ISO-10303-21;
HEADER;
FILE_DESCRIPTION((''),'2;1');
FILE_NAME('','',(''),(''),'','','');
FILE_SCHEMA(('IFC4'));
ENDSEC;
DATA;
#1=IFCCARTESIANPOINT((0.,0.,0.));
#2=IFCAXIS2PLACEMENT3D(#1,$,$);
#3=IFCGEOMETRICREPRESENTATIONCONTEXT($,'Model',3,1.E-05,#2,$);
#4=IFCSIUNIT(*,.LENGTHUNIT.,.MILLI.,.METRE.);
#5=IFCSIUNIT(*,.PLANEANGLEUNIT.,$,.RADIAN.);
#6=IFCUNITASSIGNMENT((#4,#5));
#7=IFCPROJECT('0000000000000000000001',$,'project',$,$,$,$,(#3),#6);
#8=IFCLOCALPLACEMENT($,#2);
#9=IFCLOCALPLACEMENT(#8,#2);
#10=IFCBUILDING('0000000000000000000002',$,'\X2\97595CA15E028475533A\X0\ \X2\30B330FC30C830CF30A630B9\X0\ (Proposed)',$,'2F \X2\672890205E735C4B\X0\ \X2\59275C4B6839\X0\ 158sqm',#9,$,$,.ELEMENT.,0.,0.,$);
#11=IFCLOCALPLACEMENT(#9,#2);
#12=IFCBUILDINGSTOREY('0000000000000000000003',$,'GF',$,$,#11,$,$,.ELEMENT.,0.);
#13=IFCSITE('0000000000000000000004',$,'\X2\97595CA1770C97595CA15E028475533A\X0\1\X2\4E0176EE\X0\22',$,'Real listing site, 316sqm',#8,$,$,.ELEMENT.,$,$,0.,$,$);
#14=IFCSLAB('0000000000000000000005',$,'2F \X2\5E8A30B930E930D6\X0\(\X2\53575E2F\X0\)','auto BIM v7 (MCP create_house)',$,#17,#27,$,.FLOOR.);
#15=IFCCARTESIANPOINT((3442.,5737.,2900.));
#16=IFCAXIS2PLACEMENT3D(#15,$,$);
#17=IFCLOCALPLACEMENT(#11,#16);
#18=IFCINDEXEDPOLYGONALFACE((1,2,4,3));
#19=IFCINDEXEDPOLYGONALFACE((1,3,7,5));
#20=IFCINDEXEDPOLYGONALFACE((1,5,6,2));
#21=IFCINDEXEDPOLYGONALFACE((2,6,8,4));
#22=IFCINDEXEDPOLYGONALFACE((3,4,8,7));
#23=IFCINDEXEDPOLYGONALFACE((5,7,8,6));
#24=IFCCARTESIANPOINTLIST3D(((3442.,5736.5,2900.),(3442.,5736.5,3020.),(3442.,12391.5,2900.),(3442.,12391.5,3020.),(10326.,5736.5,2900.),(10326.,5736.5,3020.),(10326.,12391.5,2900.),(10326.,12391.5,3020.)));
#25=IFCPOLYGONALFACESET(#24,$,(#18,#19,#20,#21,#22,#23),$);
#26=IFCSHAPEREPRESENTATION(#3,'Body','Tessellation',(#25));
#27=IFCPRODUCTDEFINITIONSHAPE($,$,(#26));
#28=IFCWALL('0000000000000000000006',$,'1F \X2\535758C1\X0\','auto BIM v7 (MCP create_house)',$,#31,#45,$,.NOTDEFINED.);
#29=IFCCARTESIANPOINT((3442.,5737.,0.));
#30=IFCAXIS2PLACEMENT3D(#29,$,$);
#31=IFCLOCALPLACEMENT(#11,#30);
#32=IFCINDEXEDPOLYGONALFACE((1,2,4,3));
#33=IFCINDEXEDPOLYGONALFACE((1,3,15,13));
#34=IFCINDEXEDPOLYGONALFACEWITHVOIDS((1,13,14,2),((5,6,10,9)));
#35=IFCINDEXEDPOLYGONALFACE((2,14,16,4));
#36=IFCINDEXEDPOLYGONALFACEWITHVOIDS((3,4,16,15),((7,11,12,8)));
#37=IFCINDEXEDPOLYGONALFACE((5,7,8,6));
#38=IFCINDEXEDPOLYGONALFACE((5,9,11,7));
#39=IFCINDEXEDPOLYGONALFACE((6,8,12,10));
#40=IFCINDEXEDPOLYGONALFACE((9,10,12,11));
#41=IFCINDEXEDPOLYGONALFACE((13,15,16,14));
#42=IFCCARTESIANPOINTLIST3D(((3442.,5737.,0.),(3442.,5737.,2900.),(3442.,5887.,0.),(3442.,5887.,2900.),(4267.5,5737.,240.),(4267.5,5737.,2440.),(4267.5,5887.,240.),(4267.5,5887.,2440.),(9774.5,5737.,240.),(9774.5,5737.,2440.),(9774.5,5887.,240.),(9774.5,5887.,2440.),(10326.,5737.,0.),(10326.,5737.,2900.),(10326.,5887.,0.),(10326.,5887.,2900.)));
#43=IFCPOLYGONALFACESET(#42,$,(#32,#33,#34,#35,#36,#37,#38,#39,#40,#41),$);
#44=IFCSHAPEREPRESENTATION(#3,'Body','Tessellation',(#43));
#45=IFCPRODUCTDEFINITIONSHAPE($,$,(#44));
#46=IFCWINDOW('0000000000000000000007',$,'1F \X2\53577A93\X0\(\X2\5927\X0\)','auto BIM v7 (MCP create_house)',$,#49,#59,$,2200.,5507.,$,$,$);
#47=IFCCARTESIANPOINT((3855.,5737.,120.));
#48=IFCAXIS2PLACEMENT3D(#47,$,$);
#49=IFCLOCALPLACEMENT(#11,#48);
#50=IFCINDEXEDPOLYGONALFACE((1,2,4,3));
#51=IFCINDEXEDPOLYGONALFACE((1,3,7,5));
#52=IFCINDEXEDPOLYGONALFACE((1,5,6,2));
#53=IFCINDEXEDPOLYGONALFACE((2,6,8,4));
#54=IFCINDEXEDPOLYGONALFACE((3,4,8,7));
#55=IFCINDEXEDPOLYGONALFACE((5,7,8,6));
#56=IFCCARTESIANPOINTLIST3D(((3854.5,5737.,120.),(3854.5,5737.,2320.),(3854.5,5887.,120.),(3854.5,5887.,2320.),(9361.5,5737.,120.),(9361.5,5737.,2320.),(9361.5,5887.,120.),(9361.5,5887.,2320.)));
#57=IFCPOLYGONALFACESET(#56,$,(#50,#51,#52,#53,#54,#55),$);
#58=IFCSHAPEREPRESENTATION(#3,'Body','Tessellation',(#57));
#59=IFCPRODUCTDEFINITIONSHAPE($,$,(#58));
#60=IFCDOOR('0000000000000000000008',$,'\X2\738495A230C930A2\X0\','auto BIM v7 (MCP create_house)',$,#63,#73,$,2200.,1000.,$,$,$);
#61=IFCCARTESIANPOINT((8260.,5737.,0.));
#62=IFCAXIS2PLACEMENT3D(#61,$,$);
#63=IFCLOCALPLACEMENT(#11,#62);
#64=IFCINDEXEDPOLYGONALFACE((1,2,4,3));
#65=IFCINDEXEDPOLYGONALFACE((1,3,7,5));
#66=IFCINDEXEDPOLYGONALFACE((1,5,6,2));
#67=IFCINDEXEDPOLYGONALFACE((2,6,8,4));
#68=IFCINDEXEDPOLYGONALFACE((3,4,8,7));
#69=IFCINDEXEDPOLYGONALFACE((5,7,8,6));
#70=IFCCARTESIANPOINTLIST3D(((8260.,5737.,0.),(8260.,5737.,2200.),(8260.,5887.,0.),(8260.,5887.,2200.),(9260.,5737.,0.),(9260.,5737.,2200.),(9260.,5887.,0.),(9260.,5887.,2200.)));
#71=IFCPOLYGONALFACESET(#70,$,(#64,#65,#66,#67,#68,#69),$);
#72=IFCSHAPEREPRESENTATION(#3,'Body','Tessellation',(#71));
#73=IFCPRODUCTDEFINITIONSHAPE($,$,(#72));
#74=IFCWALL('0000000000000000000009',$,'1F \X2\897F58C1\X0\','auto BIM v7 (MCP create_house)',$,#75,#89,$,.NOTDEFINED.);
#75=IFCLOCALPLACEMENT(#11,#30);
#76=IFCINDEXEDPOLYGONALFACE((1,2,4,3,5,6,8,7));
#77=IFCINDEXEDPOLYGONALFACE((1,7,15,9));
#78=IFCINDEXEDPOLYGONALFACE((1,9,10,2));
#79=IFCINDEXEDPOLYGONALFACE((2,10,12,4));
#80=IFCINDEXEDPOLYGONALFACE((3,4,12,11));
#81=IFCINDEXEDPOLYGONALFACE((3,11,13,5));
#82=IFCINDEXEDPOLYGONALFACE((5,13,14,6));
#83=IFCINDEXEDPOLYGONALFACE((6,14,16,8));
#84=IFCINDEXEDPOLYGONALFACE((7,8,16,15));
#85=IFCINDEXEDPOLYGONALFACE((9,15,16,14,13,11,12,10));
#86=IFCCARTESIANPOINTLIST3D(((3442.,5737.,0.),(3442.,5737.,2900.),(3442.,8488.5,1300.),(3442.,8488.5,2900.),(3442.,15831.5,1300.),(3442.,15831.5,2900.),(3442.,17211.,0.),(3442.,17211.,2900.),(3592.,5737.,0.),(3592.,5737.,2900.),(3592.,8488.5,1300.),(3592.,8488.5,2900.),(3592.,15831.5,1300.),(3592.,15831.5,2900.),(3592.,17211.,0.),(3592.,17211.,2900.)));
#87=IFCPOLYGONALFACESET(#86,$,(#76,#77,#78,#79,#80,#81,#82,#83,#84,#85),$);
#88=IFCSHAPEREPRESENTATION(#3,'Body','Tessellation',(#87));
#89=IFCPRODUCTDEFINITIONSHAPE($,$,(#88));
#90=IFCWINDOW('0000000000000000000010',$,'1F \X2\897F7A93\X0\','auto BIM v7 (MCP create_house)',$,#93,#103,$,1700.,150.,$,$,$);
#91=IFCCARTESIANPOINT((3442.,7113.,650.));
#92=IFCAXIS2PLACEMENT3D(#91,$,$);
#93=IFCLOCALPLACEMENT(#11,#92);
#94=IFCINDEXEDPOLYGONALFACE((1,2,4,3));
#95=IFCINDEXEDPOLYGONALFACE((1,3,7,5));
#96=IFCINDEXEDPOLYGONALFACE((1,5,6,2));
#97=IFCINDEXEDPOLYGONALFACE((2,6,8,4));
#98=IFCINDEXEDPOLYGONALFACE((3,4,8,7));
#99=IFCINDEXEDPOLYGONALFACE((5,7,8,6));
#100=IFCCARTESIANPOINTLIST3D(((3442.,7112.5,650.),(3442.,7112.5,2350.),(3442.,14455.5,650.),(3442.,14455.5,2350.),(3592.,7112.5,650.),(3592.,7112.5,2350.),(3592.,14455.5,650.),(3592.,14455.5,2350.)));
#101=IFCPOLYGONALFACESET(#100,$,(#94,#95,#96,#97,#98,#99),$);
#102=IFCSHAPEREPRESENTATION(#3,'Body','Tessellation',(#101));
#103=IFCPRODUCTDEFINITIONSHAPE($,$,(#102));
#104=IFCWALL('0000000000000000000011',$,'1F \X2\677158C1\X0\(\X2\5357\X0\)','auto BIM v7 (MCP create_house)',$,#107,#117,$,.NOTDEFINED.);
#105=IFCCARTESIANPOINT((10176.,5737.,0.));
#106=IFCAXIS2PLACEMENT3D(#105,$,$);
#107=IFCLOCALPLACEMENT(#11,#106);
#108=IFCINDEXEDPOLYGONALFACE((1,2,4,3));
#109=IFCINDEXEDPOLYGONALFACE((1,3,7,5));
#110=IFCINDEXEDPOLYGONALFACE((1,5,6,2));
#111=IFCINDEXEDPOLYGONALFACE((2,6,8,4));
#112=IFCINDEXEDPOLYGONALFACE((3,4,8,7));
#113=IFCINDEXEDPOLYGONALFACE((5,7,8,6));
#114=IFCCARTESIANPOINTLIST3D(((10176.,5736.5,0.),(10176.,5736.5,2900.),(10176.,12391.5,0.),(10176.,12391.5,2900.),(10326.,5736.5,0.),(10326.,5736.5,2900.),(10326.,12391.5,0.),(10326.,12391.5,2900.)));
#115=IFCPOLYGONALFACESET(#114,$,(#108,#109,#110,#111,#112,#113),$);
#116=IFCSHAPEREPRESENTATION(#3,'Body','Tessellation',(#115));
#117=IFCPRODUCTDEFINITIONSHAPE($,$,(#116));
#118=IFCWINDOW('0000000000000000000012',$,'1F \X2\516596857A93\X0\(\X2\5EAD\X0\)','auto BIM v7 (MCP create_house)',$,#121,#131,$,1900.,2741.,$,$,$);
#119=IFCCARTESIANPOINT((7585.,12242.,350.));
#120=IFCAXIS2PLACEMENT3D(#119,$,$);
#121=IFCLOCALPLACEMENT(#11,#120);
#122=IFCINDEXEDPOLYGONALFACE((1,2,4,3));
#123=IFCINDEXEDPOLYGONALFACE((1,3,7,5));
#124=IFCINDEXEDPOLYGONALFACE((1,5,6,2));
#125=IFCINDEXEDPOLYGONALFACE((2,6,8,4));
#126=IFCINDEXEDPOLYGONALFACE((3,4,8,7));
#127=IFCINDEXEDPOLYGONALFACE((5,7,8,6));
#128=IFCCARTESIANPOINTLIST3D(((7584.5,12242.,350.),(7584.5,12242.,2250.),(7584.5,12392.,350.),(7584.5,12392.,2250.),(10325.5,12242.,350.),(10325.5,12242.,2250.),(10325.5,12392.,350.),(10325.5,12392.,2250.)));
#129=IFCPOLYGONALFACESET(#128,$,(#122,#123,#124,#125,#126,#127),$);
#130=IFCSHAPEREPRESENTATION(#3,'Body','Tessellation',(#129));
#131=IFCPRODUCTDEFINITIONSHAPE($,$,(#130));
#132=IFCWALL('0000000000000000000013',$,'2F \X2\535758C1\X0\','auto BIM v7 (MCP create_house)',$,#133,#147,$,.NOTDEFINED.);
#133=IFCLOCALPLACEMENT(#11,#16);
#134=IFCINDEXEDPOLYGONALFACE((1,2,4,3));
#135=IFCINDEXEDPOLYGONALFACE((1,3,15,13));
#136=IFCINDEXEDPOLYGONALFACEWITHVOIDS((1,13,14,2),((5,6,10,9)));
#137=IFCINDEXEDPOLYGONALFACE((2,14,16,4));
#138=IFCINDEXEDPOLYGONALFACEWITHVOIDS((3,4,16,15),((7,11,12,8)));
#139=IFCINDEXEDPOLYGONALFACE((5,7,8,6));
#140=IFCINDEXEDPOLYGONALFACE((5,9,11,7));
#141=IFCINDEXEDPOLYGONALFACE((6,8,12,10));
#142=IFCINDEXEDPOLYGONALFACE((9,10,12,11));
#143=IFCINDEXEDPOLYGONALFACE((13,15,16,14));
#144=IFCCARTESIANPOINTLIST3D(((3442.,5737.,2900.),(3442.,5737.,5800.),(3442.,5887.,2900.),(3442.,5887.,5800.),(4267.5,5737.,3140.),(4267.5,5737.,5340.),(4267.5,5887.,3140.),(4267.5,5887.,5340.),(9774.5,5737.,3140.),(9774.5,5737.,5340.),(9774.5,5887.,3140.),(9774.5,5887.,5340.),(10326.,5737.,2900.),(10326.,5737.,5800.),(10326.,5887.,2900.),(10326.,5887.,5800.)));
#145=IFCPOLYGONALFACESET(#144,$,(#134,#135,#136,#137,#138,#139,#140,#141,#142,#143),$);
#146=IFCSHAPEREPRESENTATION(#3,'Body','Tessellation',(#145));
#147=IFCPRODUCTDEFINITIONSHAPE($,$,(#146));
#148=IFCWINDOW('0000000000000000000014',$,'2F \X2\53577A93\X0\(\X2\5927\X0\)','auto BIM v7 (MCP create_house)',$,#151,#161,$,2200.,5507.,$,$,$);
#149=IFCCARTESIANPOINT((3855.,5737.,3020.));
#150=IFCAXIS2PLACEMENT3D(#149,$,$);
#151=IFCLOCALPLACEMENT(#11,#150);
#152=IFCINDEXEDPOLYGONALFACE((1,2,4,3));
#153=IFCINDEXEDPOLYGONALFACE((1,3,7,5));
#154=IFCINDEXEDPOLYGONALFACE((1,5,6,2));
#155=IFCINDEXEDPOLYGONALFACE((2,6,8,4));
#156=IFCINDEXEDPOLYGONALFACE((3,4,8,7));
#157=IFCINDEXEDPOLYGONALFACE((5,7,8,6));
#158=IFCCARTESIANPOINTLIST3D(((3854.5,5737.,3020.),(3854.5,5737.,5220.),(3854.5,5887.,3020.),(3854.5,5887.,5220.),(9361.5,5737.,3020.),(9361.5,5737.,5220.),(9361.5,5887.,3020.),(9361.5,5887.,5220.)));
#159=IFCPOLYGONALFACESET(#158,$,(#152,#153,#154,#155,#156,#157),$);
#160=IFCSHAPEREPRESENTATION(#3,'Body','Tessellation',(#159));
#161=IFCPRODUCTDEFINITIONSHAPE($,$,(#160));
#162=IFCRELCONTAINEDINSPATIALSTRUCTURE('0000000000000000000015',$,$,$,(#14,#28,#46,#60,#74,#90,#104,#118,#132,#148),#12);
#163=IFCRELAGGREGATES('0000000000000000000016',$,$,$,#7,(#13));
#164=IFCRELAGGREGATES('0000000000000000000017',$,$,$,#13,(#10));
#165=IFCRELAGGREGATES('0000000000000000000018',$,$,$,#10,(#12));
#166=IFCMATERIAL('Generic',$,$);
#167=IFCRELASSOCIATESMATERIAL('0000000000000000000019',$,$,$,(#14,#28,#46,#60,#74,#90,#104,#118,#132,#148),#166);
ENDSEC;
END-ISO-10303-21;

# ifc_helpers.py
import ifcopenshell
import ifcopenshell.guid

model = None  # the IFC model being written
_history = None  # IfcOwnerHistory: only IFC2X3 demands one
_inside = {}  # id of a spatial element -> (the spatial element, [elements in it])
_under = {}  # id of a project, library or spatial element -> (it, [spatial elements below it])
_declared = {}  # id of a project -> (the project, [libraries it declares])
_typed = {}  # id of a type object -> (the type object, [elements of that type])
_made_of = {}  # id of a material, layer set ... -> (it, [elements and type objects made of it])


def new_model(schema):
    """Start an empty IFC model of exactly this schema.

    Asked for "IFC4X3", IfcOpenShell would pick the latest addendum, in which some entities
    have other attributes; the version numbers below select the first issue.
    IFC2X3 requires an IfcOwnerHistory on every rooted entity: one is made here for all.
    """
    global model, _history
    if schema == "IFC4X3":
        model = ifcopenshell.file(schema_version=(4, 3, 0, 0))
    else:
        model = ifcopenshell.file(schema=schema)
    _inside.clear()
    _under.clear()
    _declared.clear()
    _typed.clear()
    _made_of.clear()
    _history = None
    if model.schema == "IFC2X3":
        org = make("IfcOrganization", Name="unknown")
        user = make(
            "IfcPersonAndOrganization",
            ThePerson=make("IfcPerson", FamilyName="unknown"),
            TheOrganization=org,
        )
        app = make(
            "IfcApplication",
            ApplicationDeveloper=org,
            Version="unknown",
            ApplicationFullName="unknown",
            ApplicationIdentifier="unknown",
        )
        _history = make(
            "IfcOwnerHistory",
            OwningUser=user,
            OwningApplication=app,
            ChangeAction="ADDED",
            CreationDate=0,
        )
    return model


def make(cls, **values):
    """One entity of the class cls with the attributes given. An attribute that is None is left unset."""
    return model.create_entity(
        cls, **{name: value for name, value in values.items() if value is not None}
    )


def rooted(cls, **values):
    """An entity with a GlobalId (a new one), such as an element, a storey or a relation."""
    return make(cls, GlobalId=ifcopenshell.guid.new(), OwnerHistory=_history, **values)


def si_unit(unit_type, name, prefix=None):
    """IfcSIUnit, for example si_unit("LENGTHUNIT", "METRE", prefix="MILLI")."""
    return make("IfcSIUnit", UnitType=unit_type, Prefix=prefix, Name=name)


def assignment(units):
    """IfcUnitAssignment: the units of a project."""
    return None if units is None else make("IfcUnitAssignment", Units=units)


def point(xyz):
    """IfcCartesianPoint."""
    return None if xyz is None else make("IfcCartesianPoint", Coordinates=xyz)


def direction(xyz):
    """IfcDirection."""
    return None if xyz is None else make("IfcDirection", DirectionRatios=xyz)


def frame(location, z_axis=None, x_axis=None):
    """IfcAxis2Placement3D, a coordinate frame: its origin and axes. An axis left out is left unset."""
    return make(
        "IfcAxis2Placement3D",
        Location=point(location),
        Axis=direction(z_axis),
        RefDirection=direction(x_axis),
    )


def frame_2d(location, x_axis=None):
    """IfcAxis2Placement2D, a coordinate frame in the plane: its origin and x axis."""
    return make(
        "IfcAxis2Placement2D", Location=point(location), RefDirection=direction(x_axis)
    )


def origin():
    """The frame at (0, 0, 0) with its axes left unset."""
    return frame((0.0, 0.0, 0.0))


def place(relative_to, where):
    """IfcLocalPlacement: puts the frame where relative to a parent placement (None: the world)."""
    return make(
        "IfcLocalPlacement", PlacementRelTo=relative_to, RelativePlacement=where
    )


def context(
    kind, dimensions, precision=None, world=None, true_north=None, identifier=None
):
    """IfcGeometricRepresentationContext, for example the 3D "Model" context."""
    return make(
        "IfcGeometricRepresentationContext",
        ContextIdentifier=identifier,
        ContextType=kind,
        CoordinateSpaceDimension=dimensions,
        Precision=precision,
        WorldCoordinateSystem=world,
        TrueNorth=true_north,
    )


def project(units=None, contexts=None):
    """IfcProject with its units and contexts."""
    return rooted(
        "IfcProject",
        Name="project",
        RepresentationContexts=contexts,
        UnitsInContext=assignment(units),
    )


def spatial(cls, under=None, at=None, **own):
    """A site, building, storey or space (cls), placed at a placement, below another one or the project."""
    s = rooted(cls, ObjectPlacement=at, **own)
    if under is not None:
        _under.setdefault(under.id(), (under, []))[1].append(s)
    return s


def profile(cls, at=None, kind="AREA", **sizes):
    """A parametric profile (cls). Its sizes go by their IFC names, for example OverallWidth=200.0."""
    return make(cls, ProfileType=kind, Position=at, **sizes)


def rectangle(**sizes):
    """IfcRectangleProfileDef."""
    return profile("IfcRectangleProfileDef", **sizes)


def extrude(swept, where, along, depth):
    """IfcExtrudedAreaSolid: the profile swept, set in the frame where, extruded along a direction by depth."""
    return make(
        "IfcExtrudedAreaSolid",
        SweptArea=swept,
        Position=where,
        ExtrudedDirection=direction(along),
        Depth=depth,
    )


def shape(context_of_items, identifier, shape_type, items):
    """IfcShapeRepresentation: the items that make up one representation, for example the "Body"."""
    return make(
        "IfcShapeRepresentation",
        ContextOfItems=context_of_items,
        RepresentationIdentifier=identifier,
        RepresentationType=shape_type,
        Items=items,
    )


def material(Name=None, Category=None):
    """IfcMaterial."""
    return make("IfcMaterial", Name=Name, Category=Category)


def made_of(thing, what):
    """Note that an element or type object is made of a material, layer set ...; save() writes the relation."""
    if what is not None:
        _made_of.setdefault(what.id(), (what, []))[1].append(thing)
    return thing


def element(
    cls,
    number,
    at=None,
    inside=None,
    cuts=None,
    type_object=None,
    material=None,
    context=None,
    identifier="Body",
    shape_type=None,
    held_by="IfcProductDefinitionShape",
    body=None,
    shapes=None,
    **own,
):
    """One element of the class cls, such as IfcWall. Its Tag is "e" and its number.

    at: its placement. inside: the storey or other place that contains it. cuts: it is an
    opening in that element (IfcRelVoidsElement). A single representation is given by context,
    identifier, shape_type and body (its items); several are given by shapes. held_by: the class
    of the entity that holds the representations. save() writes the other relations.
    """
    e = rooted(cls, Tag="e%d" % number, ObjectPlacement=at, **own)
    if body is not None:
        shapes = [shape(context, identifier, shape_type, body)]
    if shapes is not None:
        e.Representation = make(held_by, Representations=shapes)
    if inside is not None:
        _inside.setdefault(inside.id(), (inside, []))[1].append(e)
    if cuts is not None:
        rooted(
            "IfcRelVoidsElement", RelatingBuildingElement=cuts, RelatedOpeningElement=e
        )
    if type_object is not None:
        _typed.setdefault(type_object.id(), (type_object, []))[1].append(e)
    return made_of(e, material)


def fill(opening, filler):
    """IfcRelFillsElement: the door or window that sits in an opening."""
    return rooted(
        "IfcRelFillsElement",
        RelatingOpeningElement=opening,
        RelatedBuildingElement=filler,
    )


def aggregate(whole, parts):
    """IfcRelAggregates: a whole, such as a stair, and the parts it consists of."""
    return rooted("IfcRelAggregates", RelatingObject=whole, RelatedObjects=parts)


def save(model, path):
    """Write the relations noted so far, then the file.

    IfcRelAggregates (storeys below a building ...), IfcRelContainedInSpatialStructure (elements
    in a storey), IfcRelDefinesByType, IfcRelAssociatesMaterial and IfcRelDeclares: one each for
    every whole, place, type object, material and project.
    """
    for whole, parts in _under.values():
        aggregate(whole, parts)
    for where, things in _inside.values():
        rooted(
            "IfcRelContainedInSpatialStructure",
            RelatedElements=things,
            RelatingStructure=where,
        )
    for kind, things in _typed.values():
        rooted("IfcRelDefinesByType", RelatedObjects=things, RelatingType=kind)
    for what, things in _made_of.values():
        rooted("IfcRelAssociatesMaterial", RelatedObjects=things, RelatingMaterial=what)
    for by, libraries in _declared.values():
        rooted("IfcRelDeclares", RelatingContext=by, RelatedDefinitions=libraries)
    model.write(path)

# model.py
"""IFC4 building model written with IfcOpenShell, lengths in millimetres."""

from ifc_helpers import new_model, si_unit, frame, frame_2d, origin, place, context, project, spatial, rectangle, extrude, material, element, fill, save


model = new_model("IFC4")

# Units and contexts
model_context = context("Model", 3, precision=1e-05, world=origin())
ifc_project = project(units=[si_unit("LENGTHUNIT", "METRE", prefix="MILLI"), si_unit("PLANEANGLEUNIT", "RADIAN")], contexts=[model_context])

# Site, building, storey
site_placement = place(None, origin())
site = spatial("IfcSite", under=ifc_project, at=site_placement, Name="静岡県静岡市葵区1丁目22", ObjectType="Real listing site, 316sqm", CompositionType="ELEMENT", RefElevation=0.0)
building_placement = place(site_placement, origin())
building = spatial("IfcBuilding", under=site, at=building_placement, Name="静岡市葵区 コートハウス (Proposed)", ObjectType="2F 木造平屋 大屋根 158sqm", CompositionType="ELEMENT", ElevationOfRefHeight=0.0, ElevationOfTerrain=0.0)
storey_placement = place(building_placement, origin())
storey = spatial("IfcBuildingStorey", under=building, at=storey_placement, Name="GF", CompositionType="ELEMENT", Elevation=0.0)

# Slab
ifc_material = material(Name="Generic")
slab_1_placement = place(storey_placement, frame((3442.0, 5737.0, 2900.0)))
element("IfcSlab", 1, at=slab_1_placement, inside=storey, material=ifc_material, Name="2F 床スラブ(南帯)", Description="auto BIM v7 (MCP create_house)", PredefinedType="FLOOR", context=model_context, shape_type="SweptSolid", body=[
    extrude(rectangle(XDim=6884.0, YDim=6655.0, at=frame_2d((3442.0, 3327.0))), frame((3442.0, 5737.0, 2900.0)), (0.0, 0.0, 1.0), 120.0),
])

# Wall, openings, window, door
wall_1_placement = place(storey_placement, frame((3442.0, 5737.0, 0.0)))
wall_1 = element("IfcWall", 2, at=wall_1_placement, inside=storey, material=ifc_material, Name="1F 南壁", Description="auto BIM v7 (MCP create_house)", PredefinedType="NOTDEFINED", context=model_context, shape_type="SweptSolid", body=[
    extrude(rectangle(XDim=6884.0, YDim=150.0, at=frame_2d((3442.0, 75.0))), frame((3442.0, 5737.0, 0.0)), (0.0, 0.0, 1.0), 2900.0),
])
opening_1_placement = place(storey_placement, frame((3855.0, 5737.0, 120.0)))
opening_1 = element("IfcOpeningElement", 3, at=opening_1_placement, cuts=wall_1, PredefinedType="NOTDEFINED", context=model_context, shape_type="SweptSolid", body=[
    extrude(rectangle(XDim=5507.0, YDim=150.0, at=frame_2d((2753.0, 75.0))), frame((3855.0, 5737.0, 120.0)), (0.0, 0.0, 1.0), 2200.0),
])
opening_2_placement = place(storey_placement, frame((8260.0, 5737.0, 0.0)))
opening_2 = element("IfcOpeningElement", 4, at=opening_2_placement, cuts=wall_1, PredefinedType="NOTDEFINED", context=model_context, shape_type="SweptSolid", body=[
    extrude(rectangle(XDim=1000.0, YDim=150.0, at=frame_2d((500.0, 75.0))), frame((8260.0, 5737.0, 0.0)), (0.0, 0.0, 1.0), 2200.0),
])
window_1_placement = place(storey_placement, frame((3855.0, 5737.0, 120.0)))
window_1 = element("IfcWindow", 5, at=window_1_placement, inside=storey, material=ifc_material, Name="1F 南窓(大)", Description="auto BIM v7 (MCP create_house)", OverallHeight=2200.0, OverallWidth=5507.0, context=model_context, shape_type="SweptSolid", body=[
    extrude(rectangle(XDim=5507.0, YDim=150.0, at=frame_2d((2753.0, 75.0))), frame((3855.0, 5737.0, 120.0)), (0.0, 0.0, 1.0), 2200.0),
])
fill(opening_1, window_1)
door_placement = place(storey_placement, frame((8260.0, 5737.0, 0.0)))
door = element("IfcDoor", 6, at=door_placement, inside=storey, material=ifc_material, Name="玄関ドア", Description="auto BIM v7 (MCP create_house)", OverallHeight=2200.0, OverallWidth=1000.0, context=model_context, shape_type="SweptSolid", body=[
    extrude(rectangle(XDim=1000.0, YDim=150.0, at=frame_2d((500.0, 75.0))), frame((8260.0, 5737.0, 0.0)), (0.0, 0.0, 1.0), 2200.0),
])
fill(opening_2, door)

# Walls, openings, windows
wall_2_placement = place(storey_placement, frame((3442.0, 5737.0, 0.0)))
wall_2 = element("IfcWall", 7, at=wall_2_placement, inside=storey, material=ifc_material, Name="1F 西壁", Description="auto BIM v7 (MCP create_house)", PredefinedType="NOTDEFINED", context=model_context, shape_type="SweptSolid", body=[
    extrude(rectangle(XDim=150.0, YDim=11474.0, at=frame_2d((75.0, 5737.0))), frame((3442.0, 5737.0, 0.0)), (0.0, 0.0, 1.0), 2900.0),
])
opening_3_placement = place(storey_placement, frame((3442.0, 7113.0, 650.0)))
opening_3 = element("IfcOpeningElement", 8, at=opening_3_placement, cuts=wall_2, PredefinedType="NOTDEFINED", context=model_context, shape_type="SweptSolid", body=[
    extrude(rectangle(XDim=150.0, YDim=7343.0, at=frame_2d((75.0, 3671.0))), frame((3442.0, 7113.0, 650.0)), (0.0, 0.0, 1.0), 1700.0),
])
window_2_placement = place(storey_placement, frame((3442.0, 7113.0, 650.0)))
window_2 = element("IfcWindow", 9, at=window_2_placement, inside=storey, material=ifc_material, Name="1F 西窓", Description="auto BIM v7 (MCP create_house)", OverallHeight=1700.0, OverallWidth=150.0, context=model_context, shape_type="SweptSolid", body=[
    extrude(rectangle(XDim=150.0, YDim=7343.0, at=frame_2d((75.0, 3671.0))), frame((3442.0, 7113.0, 650.0)), (0.0, 0.0, 1.0), 1700.0),
])
fill(opening_3, window_2)
wall_3_placement = place(storey_placement, frame((10176.0, 5737.0, 0.0)))
wall_3 = element("IfcWall", 10, at=wall_3_placement, inside=storey, material=ifc_material, Name="1F 東壁(南)", Description="auto BIM v7 (MCP create_house)", PredefinedType="NOTDEFINED", context=model_context, shape_type="SweptSolid", body=[
    extrude(rectangle(XDim=150.0, YDim=6655.0, at=frame_2d((75.0, 3327.0))), frame((10176.0, 5737.0, 0.0)), (0.0, 0.0, 1.0), 2900.0),
])
opening_4_placement = place(storey_placement, frame((7585.0, 12242.0, 350.0)))
opening_4 = element("IfcOpeningElement", 11, at=opening_4_placement, cuts=wall_3, PredefinedType="NOTDEFINED", context=model_context, shape_type="SweptSolid", body=[
    extrude(rectangle(XDim=2741.0, YDim=150.0, at=frame_2d((1370.0, 75.0))), frame((7585.0, 12242.0, 350.0)), (0.0, 0.0, 1.0), 1900.0),
])
window_3_placement = place(storey_placement, frame((7585.0, 12242.0, 350.0)))
window_3 = element("IfcWindow", 12, at=window_3_placement, inside=storey, material=ifc_material, Name="1F 入隅窓(庭)", Description="auto BIM v7 (MCP create_house)", OverallHeight=1900.0, OverallWidth=2741.0, context=model_context, shape_type="SweptSolid", body=[
    extrude(rectangle(XDim=2741.0, YDim=150.0, at=frame_2d((1370.0, 75.0))), frame((7585.0, 12242.0, 350.0)), (0.0, 0.0, 1.0), 1900.0),
])
fill(opening_4, window_3)

# Wall, opening, window
wall_4_placement = place(storey_placement, frame((3442.0, 5737.0, 2900.0)))
wall_4 = element("IfcWall", 13, at=wall_4_placement, inside=storey, material=ifc_material, Name="2F 南壁", Description="auto BIM v7 (MCP create_house)", PredefinedType="NOTDEFINED", context=model_context, shape_type="SweptSolid", body=[
    extrude(rectangle(XDim=6884.0, YDim=150.0, at=frame_2d((3442.0, 75.0))), frame((3442.0, 5737.0, 2900.0)), (0.0, 0.0, 1.0), 2900.0),
])
opening_5_placement = place(storey_placement, frame((3855.0, 5737.0, 3020.0)))
opening_5 = element("IfcOpeningElement", 14, at=opening_5_placement, cuts=wall_4, PredefinedType="NOTDEFINED", context=model_context, shape_type="SweptSolid", body=[
    extrude(rectangle(XDim=5507.0, YDim=150.0, at=frame_2d((2753.0, 75.0))), frame((3855.0, 5737.0, 3020.0)), (0.0, 0.0, 1.0), 2200.0),
])
window_4_placement = place(storey_placement, frame((3855.0, 5737.0, 3020.0)))
window_4 = element("IfcWindow", 15, at=window_4_placement, inside=storey, material=ifc_material, Name="2F 南窓(大)", Description="auto BIM v7 (MCP create_house)", OverallHeight=2200.0, OverallWidth=5507.0, context=model_context, shape_type="SweptSolid", body=[
    extrude(rectangle(XDim=5507.0, YDim=150.0, at=frame_2d((2753.0, 75.0))), frame((3855.0, 5737.0, 3020.0)), (0.0, 0.0, 1.0), 2200.0),
])
fill(opening_5, window_4)

save(model, "model.ifc")
